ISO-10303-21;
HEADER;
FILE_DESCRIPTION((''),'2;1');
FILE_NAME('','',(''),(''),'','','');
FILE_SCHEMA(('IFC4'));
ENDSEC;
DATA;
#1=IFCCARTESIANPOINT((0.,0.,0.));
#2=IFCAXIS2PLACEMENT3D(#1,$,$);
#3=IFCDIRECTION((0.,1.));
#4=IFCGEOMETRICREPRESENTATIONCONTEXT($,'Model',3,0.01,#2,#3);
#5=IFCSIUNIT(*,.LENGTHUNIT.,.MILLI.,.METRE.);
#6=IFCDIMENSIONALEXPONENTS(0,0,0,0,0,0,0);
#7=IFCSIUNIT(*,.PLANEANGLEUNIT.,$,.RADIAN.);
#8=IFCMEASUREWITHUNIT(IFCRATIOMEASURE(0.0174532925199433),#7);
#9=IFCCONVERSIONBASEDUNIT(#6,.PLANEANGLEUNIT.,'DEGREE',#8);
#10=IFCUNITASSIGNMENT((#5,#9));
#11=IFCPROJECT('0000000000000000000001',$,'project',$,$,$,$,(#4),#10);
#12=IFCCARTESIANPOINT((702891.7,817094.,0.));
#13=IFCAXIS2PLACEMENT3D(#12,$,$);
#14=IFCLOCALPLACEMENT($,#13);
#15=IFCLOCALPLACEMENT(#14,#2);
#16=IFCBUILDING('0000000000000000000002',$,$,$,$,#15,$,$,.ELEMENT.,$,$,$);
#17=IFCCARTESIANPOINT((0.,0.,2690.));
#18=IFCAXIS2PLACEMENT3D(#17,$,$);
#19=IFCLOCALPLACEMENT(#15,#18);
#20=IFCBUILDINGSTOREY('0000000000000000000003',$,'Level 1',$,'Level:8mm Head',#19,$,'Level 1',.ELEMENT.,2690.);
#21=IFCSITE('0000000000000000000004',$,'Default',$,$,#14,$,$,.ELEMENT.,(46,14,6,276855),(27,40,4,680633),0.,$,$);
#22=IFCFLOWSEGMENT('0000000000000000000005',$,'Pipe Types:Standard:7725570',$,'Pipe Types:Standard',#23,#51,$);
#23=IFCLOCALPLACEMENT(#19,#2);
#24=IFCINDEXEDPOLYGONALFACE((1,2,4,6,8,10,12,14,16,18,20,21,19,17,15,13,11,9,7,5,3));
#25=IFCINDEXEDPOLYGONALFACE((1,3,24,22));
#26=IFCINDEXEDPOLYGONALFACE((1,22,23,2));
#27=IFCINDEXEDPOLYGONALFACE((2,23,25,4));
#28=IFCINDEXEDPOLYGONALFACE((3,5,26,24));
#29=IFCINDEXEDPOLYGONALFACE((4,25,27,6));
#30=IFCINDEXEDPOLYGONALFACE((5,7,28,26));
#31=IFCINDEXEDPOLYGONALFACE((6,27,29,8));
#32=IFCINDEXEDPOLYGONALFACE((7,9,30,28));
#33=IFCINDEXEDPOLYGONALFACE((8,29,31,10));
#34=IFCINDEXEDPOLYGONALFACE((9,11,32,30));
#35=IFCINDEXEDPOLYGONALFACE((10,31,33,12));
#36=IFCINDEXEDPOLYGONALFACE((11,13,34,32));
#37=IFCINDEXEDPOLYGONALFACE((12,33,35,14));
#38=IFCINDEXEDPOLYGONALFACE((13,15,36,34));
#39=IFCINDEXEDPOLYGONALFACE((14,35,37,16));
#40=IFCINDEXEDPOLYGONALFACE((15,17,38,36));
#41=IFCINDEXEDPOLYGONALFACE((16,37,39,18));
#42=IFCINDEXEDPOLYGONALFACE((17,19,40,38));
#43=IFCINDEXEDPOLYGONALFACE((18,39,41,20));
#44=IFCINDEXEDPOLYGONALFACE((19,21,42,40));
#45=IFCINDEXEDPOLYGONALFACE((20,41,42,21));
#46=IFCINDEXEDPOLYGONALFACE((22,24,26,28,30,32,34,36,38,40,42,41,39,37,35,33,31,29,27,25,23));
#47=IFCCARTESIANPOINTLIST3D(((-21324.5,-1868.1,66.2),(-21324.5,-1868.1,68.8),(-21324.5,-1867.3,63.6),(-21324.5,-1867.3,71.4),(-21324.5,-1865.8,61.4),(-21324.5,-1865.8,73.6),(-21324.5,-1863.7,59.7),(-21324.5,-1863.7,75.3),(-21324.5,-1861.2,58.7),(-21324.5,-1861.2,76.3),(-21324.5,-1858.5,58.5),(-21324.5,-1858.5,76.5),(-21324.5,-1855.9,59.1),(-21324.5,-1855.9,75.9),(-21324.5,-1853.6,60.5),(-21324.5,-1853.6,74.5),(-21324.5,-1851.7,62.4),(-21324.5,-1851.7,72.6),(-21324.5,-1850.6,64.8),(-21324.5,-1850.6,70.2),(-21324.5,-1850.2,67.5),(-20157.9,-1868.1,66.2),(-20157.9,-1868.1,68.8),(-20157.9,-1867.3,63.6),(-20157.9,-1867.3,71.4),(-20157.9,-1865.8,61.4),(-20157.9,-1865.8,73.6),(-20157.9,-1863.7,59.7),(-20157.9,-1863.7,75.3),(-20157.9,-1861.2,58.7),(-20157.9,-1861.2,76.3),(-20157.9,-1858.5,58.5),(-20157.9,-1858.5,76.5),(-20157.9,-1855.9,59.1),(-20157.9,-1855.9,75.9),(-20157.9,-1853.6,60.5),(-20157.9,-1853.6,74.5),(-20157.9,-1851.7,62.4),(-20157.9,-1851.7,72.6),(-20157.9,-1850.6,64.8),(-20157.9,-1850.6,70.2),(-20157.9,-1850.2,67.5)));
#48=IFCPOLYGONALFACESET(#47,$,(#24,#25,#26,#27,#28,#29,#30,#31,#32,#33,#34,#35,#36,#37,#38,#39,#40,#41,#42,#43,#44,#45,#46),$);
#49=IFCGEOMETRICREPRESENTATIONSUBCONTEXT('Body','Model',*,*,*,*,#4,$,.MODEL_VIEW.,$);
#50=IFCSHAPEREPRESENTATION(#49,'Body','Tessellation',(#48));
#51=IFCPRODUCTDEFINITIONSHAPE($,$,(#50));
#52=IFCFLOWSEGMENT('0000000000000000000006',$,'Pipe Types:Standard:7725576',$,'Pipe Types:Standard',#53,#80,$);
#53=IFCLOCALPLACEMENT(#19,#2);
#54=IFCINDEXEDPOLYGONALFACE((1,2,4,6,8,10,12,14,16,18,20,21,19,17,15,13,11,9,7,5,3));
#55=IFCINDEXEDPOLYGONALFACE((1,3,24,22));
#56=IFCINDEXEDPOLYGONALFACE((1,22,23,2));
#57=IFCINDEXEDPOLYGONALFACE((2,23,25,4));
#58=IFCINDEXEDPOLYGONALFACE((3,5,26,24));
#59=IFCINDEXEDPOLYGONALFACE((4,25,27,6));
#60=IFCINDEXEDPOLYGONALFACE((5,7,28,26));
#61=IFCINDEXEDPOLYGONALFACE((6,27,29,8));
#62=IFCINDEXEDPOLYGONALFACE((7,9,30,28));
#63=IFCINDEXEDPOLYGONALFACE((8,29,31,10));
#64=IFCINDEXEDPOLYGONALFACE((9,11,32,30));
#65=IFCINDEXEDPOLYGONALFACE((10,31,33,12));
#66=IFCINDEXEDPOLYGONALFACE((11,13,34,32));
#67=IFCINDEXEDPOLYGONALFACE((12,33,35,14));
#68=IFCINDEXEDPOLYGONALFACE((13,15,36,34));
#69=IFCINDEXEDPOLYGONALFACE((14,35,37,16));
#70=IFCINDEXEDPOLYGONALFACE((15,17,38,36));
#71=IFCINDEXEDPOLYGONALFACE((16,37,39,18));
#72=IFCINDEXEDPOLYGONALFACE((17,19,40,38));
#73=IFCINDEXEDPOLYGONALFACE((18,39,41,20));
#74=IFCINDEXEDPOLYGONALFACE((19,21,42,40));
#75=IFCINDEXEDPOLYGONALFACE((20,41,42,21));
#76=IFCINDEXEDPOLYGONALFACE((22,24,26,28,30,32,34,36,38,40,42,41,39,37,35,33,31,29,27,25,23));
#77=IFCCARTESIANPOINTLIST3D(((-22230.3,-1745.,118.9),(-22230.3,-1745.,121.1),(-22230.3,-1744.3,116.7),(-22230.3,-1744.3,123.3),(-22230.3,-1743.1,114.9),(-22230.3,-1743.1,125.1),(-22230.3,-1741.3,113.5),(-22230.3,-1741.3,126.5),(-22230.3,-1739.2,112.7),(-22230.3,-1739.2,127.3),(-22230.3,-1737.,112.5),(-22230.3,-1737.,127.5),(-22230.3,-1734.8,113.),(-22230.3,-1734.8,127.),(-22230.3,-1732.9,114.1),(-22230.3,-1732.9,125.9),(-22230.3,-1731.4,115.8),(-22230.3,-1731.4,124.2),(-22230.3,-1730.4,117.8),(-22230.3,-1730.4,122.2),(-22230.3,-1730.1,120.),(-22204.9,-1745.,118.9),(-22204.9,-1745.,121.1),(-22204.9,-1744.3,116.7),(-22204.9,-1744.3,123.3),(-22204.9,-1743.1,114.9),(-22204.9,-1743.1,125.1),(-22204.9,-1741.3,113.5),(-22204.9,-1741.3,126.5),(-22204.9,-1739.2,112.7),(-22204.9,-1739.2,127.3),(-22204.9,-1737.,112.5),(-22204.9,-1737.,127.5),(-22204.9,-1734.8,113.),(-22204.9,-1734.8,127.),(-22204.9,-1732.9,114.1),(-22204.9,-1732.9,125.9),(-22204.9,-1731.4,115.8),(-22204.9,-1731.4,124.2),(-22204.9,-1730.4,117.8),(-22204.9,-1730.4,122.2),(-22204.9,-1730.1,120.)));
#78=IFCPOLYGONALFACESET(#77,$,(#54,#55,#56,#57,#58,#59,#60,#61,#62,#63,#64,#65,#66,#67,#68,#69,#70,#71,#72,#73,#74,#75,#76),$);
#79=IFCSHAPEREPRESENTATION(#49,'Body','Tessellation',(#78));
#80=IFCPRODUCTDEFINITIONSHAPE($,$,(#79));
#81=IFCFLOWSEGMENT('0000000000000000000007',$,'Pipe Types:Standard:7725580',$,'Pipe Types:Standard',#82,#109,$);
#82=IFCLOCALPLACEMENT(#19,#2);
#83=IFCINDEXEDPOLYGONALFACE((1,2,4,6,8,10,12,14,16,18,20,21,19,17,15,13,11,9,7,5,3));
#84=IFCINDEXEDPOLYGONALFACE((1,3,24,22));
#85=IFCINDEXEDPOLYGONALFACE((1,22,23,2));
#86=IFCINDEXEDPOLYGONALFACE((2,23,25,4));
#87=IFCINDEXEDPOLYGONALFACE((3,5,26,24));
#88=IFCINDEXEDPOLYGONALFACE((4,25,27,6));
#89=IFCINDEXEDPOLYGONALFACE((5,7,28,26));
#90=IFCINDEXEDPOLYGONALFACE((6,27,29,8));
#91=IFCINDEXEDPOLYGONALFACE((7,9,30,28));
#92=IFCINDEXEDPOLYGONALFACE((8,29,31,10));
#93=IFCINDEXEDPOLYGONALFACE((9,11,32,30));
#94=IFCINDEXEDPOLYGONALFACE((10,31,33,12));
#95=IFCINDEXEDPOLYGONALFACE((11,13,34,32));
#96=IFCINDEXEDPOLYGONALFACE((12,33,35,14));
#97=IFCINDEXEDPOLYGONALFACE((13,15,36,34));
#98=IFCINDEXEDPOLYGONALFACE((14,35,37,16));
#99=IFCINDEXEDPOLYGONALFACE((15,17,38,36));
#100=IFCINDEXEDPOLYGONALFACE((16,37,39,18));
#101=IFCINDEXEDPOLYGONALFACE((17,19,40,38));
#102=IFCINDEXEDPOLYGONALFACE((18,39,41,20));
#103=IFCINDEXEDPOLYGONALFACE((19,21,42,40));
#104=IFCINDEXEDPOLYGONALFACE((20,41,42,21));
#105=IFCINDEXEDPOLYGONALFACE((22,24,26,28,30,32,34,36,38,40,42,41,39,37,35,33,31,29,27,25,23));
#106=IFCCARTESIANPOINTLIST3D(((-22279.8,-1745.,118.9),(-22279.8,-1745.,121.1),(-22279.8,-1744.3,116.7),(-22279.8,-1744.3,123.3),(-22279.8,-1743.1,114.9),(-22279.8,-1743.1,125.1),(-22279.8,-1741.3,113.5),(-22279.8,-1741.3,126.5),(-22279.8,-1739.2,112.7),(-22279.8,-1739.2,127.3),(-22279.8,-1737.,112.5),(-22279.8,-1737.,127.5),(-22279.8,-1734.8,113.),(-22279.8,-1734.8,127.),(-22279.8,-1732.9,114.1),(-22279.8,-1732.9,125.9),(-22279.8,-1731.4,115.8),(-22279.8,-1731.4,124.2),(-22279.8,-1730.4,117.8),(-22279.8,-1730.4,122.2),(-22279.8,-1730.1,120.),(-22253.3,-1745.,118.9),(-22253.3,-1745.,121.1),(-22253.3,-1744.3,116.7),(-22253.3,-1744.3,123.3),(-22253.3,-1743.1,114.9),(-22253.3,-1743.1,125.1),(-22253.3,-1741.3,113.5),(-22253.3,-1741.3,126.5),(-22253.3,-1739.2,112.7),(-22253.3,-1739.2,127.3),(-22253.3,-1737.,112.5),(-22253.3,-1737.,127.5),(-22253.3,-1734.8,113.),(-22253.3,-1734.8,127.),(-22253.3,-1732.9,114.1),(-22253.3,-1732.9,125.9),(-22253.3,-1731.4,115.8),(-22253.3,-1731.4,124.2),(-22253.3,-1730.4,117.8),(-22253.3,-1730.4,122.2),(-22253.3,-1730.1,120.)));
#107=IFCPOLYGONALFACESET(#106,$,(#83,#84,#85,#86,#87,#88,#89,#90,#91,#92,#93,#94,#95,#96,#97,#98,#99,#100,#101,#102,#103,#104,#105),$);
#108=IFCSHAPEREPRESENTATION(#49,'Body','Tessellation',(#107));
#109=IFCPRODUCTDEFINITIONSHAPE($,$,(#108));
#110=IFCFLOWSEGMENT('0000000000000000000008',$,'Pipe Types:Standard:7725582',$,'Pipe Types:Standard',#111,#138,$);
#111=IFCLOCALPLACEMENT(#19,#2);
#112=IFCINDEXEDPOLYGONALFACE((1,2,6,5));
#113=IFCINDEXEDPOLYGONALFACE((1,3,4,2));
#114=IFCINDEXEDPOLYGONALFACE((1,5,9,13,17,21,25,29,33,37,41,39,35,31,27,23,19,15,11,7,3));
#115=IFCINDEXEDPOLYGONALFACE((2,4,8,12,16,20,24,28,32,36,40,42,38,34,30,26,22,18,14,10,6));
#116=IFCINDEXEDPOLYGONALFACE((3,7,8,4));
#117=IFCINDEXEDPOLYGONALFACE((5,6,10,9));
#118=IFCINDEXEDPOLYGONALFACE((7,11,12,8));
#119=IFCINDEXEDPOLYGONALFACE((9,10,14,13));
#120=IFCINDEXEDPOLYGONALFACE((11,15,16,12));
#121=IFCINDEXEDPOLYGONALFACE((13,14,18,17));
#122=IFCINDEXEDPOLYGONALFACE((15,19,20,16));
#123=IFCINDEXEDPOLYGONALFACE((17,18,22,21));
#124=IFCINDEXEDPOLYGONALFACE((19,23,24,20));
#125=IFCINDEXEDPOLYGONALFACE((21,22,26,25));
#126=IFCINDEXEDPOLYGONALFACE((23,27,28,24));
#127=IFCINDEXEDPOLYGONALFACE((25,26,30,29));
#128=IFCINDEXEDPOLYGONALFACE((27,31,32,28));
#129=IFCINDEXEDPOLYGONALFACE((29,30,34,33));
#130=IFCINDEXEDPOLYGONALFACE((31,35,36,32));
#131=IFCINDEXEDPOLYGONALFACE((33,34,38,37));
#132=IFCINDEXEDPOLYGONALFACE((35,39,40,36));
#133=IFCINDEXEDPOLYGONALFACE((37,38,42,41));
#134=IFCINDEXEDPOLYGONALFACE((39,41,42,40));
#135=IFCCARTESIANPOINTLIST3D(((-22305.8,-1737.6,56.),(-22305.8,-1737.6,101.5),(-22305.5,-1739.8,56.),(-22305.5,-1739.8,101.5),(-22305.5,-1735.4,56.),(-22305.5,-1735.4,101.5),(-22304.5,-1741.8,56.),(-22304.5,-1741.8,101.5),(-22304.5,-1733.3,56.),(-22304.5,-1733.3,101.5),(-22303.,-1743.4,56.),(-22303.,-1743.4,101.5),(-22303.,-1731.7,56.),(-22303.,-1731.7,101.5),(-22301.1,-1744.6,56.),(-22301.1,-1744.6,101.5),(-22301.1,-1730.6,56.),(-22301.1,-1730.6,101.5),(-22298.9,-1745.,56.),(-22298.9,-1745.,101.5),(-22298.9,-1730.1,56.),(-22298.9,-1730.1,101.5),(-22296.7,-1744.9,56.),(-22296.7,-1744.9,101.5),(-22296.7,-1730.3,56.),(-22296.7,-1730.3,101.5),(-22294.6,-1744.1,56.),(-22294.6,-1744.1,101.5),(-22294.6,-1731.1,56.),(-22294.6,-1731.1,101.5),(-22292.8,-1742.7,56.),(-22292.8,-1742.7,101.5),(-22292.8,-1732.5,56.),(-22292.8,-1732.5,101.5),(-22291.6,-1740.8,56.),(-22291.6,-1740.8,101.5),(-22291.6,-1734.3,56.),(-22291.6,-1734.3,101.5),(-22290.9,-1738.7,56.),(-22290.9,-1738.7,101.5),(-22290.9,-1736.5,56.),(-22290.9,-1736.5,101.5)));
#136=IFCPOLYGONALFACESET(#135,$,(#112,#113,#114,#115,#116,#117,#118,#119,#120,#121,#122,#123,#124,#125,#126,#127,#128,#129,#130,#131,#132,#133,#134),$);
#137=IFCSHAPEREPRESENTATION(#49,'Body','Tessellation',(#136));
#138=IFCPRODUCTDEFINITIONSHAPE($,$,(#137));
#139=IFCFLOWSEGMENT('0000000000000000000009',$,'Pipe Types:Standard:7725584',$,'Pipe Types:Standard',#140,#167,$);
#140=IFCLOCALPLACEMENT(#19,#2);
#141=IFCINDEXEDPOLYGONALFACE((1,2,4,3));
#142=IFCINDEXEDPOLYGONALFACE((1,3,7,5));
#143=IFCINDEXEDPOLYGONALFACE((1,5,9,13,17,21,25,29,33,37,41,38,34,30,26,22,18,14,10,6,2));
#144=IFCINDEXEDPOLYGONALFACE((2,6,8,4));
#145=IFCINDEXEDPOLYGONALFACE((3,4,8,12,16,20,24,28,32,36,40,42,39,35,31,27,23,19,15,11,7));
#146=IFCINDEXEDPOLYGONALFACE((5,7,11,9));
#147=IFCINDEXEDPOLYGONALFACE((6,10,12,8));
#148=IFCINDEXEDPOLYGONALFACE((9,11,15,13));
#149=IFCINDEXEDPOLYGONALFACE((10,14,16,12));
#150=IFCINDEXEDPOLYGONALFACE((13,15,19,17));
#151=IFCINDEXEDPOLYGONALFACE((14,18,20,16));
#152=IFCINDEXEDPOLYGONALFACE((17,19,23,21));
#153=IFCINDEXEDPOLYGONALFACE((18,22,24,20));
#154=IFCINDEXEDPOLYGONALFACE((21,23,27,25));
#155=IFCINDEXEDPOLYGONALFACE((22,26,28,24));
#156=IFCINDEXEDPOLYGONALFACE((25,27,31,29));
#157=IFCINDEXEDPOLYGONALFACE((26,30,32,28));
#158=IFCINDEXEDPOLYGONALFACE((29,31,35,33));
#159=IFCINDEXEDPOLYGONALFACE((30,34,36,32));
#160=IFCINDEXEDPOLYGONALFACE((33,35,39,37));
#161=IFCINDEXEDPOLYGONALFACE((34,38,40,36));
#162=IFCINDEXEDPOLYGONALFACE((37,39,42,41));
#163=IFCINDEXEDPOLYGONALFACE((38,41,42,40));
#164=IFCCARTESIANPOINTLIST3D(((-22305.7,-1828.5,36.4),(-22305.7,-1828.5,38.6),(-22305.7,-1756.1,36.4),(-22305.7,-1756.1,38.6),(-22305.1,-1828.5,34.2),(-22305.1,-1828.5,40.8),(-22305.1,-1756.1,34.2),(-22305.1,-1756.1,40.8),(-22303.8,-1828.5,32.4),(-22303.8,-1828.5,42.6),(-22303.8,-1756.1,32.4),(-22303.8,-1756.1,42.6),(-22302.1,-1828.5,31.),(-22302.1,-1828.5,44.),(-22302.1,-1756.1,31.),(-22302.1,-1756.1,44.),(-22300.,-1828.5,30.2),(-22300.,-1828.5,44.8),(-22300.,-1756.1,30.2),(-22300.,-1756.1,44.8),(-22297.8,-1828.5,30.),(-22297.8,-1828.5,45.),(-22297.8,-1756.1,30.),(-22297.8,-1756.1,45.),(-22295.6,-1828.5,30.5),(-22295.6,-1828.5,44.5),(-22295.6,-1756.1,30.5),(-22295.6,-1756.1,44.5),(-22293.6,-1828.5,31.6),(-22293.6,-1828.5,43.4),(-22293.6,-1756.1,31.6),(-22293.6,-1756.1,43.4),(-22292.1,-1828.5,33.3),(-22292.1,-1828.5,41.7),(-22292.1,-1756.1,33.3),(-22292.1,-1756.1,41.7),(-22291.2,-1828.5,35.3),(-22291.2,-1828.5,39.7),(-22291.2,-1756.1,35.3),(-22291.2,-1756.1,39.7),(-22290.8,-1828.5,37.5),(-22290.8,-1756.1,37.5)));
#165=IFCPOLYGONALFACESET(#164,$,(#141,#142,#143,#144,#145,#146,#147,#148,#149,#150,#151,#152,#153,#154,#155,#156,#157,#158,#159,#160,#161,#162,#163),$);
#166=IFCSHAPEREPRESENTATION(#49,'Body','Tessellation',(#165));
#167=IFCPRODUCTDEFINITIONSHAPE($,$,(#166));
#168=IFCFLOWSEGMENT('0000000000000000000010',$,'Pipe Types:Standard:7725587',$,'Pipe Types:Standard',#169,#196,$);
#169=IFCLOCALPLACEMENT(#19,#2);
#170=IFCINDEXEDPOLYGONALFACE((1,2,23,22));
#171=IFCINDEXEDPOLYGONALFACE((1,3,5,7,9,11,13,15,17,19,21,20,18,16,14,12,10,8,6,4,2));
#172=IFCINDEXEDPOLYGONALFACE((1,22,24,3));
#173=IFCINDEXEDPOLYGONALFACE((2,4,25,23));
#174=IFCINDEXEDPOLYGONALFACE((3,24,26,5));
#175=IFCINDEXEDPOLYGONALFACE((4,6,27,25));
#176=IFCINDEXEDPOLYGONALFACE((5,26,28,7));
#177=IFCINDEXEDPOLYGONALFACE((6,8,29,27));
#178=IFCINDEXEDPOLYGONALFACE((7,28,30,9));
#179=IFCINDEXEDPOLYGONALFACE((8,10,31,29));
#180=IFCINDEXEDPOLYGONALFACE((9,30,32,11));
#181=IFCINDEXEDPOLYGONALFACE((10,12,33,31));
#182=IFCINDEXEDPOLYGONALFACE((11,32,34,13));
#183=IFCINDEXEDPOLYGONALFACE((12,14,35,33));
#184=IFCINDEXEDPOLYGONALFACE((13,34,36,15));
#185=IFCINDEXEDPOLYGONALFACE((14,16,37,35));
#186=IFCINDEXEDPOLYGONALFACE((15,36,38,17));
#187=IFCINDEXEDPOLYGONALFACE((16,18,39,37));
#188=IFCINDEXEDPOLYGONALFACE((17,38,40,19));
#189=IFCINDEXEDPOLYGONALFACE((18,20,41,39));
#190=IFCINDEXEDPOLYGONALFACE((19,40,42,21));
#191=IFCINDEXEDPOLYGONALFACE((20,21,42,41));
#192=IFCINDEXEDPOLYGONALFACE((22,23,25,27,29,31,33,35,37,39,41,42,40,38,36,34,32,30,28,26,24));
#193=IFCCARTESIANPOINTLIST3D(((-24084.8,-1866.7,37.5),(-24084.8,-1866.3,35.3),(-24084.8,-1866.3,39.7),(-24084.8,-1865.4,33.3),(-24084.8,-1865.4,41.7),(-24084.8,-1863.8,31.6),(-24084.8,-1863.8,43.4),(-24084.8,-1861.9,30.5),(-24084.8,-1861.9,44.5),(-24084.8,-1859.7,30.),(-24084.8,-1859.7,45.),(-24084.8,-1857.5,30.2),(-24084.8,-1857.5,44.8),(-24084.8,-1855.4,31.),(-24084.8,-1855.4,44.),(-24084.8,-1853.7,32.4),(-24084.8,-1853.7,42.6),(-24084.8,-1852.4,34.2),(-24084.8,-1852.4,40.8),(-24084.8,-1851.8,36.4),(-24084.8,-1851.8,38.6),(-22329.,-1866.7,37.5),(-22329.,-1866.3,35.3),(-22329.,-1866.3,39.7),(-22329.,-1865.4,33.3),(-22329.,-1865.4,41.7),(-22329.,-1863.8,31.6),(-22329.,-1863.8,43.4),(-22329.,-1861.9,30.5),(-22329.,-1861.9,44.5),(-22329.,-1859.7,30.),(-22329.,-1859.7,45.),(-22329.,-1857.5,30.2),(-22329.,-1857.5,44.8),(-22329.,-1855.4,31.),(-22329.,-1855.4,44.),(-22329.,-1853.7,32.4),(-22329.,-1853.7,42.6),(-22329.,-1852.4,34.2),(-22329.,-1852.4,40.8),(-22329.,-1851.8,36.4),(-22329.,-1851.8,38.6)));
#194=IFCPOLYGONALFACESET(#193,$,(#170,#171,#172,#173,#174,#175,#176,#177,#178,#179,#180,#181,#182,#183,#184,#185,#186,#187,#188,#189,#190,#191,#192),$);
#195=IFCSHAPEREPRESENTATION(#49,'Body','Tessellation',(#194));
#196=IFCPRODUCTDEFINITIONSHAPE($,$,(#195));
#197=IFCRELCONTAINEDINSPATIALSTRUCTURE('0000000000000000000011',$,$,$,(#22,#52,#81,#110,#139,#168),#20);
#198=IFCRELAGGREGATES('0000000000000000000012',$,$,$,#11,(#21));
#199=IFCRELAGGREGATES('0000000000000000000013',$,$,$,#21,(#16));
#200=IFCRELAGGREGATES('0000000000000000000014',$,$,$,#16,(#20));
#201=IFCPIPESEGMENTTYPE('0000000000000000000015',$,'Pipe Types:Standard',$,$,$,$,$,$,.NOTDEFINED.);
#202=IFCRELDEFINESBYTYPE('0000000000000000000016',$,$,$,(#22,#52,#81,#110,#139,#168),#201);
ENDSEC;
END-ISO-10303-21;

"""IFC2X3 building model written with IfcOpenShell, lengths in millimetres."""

from ifc_helpers import new_model, entity, si_unit, converted_unit, direction, frame, frame_2d, origin, origin_2d_with_axis, place, context, subcontext, project, spatial, circle, extrude, type_object, element, save


model = new_model("IFC2X3")

# Units and contexts
model_context = context("Model", 3, precision=0.01, world=origin(), true_north=direction((0.0, 1.0)))
body_context = subcontext(model_context, "Body", "Model", "MODEL_VIEW")
ifc_project = project(units=[si_unit("LENGTHUNIT", "METRE", prefix="MILLI"), converted_unit("PLANEANGLEUNIT", "DEGREE", entity("IfcRatioMeasure", 0.0174532925199433), si_unit("PLANEANGLEUNIT", "RADIAN"), dimensions=[0, 0, 0, 0, 0, 0, 0])], contexts=[model_context])

# Site, building, storey
site_placement = place(None, frame((702891.7, 817094.0, 0.0)))
site = spatial("IfcSite", under=ifc_project, at=site_placement, Name="Default", CompositionType="ELEMENT", RefLatitude=(46, 14, 6, 276855), RefLongitude=(27, 40, 4, 680633), RefElevation=0.0)
building_placement = place(site_placement, origin())
building = spatial("IfcBuilding", under=site, at=building_placement, CompositionType="ELEMENT")
storey_placement = place(building_placement, frame((0.0, 0.0, 2690.0)))
storey = spatial("IfcBuildingStorey", under=building, at=storey_placement, Name="Level 1", ObjectType="Level:8mm Head", LongName="Level 1", CompositionType="ELEMENT", Elevation=2690.0)

# Flow segments
pipe_segment_type = type_object("IfcPipeSegmentType", Name="Pipe Types:Standard", PredefinedType="NOTDEFINED")
flow_segment_1_placement = place(storey_placement, origin())
element("IfcFlowSegment", 1, at=flow_segment_1_placement, inside=storey, type_object=pipe_segment_type, Name="Pipe Types:Standard:7725570", ObjectType="Pipe Types:Standard", context=body_context, shape_type="SweptSolid", body=[
    extrude(circle(Radius=9.0, at=frame_2d((0.0, 0.0), x_axis=(1.0, 0.0))), frame((-21324.5, -1859.2, 67.5), z_axis=(1.0, 0.0, 0.0), x_axis=(0.0, 1.0, 0.0)), (0.0, 0.0, 1.0), 1166.6),
])
flow_segment_2_placement = place(storey_placement, origin())
element("IfcFlowSegment", 2, at=flow_segment_2_placement, inside=storey, type_object=pipe_segment_type, Name="Pipe Types:Standard:7725576", ObjectType="Pipe Types:Standard", context=body_context, shape_type="SweptSolid", body=[
    extrude(circle(Radius=7.5, at=frame_2d((0.0, 0.0), x_axis=(1.0, 0.0))), frame((-22230.3, -1737.6, 120.0), z_axis=(1.0, 0.0, 0.0), x_axis=(0.0, 1.0, 0.0)), (0.0, 0.0, 1.0), 25.4),
])
flow_segment_3_placement = place(storey_placement, origin())
element("IfcFlowSegment", 3, at=flow_segment_3_placement, inside=storey, type_object=pipe_segment_type, Name="Pipe Types:Standard:7725580", ObjectType="Pipe Types:Standard", context=body_context, shape_type="SweptSolid", body=[
    extrude(circle(Radius=7.5, at=origin_2d_with_axis()), frame((-22279.8, -1737.6, 120.0), z_axis=(1.0, 0.0, 0.0), x_axis=(0.0, 1.0, 0.0)), (0.0, 0.0, 1.0), 26.5),
])
flow_segment_4_placement = place(storey_placement, origin())
element("IfcFlowSegment", 4, at=flow_segment_4_placement, inside=storey, type_object=pipe_segment_type, Name="Pipe Types:Standard:7725582", ObjectType="Pipe Types:Standard", context=body_context, shape_type="SweptSolid", body=[
    extrude(circle(Radius=7.5, at=origin_2d_with_axis()), frame((-22298.3, -1737.6, 56.0), z_axis=(0.0, 0.0, 1.0), x_axis=(-1.0, 0.0, 0.0)), (0.0, 0.0, 1.0), 45.5),
])
flow_segment_5_placement = place(storey_placement, origin())
element("IfcFlowSegment", 5, at=flow_segment_5_placement, inside=storey, type_object=pipe_segment_type, Name="Pipe Types:Standard:7725584", ObjectType="Pipe Types:Standard", context=body_context, shape_type="SweptSolid", body=[
    extrude(circle(Radius=7.5, at=origin_2d_with_axis()), frame((-22298.3, -1828.5, 37.5), z_axis=(0.0, 1.0, 0.0), x_axis=(1.0, 0.0, 0.0)), (0.0, 0.0, 1.0), 72.4),
])
flow_segment_6_placement = place(storey_placement, origin())
element("IfcFlowSegment", 6, at=flow_segment_6_placement, inside=storey, type_object=pipe_segment_type, Name="Pipe Types:Standard:7725587", ObjectType="Pipe Types:Standard", context=body_context, shape_type="SweptSolid", body=[
    extrude(circle(Radius=7.5, at=origin_2d_with_axis()), frame((-24084.8, -1859.2, 37.5), z_axis=(1.0, 0.0, 0.0), x_axis=(0.0, -1.0, 0.0)), (0.0, 0.0, 1.0), 1755.8),
])

save(model, "model.ifc")
